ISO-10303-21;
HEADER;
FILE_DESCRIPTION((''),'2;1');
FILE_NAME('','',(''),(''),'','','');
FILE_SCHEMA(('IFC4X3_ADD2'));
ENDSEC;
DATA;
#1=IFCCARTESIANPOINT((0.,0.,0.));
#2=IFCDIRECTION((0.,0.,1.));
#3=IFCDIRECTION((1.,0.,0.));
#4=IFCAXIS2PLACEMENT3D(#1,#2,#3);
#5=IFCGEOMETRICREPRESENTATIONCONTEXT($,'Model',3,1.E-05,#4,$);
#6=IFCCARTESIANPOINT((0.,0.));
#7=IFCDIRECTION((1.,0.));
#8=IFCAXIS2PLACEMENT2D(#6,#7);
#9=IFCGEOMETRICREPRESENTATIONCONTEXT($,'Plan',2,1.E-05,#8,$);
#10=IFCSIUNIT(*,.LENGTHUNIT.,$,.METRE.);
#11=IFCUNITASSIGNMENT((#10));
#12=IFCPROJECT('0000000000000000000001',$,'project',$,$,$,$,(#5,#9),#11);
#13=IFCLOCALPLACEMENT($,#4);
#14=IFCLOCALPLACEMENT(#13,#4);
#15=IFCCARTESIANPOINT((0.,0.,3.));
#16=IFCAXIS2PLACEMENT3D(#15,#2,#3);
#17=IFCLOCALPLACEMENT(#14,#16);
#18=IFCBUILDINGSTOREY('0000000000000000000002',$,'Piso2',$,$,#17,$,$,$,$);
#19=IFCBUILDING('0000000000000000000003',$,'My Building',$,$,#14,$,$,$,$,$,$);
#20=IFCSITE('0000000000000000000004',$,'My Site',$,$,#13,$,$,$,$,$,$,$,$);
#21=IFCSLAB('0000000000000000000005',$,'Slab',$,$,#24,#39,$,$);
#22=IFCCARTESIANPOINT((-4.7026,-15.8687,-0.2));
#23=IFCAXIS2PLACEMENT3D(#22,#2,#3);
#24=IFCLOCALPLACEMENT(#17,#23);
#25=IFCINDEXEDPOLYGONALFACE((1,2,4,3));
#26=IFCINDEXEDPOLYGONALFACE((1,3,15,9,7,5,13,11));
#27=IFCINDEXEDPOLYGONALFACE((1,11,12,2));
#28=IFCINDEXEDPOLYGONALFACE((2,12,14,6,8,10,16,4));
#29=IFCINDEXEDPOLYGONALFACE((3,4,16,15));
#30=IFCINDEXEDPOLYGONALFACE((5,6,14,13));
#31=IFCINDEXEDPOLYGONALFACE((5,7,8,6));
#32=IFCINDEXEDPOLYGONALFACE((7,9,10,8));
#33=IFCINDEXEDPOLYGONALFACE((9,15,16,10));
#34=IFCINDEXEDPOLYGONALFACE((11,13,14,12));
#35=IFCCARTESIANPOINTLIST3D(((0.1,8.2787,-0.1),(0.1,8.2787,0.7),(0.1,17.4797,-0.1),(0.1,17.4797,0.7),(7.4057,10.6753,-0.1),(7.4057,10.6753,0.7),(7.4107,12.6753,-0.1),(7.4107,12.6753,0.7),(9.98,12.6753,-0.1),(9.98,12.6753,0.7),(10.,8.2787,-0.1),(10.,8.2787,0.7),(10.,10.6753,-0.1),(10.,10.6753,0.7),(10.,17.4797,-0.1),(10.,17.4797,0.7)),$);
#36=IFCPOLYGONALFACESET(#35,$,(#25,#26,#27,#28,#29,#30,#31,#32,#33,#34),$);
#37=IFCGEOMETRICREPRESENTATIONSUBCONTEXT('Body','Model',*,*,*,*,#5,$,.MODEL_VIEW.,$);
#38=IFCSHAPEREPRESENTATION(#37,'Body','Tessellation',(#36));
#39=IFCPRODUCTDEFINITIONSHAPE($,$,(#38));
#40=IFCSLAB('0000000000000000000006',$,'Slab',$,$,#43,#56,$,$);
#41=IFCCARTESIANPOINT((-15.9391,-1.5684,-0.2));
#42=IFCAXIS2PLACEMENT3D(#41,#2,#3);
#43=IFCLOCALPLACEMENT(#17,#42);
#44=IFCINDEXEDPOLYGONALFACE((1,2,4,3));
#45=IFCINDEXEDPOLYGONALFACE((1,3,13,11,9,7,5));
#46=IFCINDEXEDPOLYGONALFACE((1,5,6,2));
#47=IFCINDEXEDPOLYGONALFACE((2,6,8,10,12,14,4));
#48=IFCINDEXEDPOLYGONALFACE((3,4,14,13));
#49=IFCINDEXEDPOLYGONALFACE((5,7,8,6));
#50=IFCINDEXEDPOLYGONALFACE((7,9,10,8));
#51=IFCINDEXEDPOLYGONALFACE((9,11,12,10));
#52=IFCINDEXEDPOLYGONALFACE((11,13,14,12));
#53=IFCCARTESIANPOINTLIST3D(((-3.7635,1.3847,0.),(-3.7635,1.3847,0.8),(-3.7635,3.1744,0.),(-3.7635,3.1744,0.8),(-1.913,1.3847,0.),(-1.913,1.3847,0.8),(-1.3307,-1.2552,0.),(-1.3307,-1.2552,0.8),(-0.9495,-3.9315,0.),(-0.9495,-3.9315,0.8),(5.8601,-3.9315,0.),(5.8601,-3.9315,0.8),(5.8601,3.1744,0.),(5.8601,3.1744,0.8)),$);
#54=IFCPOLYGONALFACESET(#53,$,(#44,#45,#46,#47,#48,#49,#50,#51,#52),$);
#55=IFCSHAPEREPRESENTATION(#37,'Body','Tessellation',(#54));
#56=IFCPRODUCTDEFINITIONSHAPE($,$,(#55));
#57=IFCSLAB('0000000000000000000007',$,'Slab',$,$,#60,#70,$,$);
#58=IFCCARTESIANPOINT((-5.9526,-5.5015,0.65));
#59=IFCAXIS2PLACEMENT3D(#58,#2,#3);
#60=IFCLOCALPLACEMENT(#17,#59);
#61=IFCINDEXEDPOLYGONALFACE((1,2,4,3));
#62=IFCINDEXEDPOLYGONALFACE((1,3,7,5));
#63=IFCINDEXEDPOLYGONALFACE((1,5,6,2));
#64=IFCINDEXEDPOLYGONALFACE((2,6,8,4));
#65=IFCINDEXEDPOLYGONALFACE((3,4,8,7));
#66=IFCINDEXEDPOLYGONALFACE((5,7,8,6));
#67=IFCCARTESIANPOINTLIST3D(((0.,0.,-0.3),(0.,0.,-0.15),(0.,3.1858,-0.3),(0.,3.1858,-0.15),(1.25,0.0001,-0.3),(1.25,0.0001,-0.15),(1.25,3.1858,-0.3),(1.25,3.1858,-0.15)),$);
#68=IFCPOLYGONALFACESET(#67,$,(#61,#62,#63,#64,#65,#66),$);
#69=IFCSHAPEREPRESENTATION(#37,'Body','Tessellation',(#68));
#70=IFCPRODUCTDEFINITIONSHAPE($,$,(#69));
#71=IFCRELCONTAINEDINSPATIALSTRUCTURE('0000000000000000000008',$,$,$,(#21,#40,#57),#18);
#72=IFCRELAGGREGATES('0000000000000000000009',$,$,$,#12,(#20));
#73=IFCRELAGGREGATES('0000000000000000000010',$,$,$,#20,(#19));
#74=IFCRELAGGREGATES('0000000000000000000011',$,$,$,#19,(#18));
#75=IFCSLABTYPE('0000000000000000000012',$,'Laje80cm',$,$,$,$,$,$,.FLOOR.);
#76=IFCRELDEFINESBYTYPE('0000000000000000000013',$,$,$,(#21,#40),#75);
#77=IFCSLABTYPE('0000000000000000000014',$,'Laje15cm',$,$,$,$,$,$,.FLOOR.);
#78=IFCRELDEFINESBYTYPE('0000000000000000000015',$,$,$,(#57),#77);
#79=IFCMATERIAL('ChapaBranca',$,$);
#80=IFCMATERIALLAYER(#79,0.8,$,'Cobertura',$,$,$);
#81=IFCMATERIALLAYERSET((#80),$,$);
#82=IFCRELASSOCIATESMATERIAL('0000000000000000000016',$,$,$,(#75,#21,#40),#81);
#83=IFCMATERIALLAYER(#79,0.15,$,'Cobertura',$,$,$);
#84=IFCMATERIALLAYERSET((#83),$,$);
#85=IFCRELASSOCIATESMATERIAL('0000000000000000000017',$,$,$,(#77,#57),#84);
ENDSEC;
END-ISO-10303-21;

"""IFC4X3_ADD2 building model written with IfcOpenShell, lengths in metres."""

from ifc_helpers import new_model, si_unit, frame, origin_with_axes, origin_2d_with_axis, place, context, subcontext, project, spatial, line, indexed_curve, outline, extrude, material, layer, layer_set, layer_usage, type_object, element, save


model = new_model("IFC4X3_ADD2")

# Units and contexts
model_context = context("Model", 3, precision=1e-05, world=origin_with_axes())
plan_context = context("Plan", 2, precision=1e-05, world=origin_2d_with_axis())
body_context = subcontext(model_context, "Body", "Model", "MODEL_VIEW")
ifc_project = project(units=[si_unit("LENGTHUNIT", "METRE")], contexts=[model_context, plan_context])

# Site, building, storey
site_placement = place(None, origin_with_axes())
site = spatial("IfcSite", under=ifc_project, at=site_placement, Name="My Site")
building_placement = place(site_placement, origin_with_axes())
building = spatial("IfcBuilding", under=site, at=building_placement, Name="My Building")
storey_placement = place(building_placement, frame((0.0, 0.0, 3.0), z_axis=(0.0, 0.0, 1.0), x_axis=(1.0, 0.0, 0.0)))
storey = spatial("IfcBuildingStorey", under=building, at=storey_placement, Name="Piso2")

# Shared definitions
ifc_material_1 = material(Name="ChapaBranca")

# Slabs
ifc_layer_1 = layer(ifc_material_1, 0.8, Name="Cobertura")
ifc_layer_set_1 = layer_set([ifc_layer_1])
ifc_layer_usage_1 = layer_usage(ifc_layer_set_1, "AXIS3", "POSITIVE", -0.1)
slab_type_1 = type_object("IfcSlabType", Name="Laje80cm", PredefinedType="FLOOR", material=ifc_layer_set_1)
slab_1_placement = place(storey_placement, frame((-4.7026, -15.8687, -0.2), z_axis=(0.0, 0.0, 1.0), x_axis=(1.0, 0.0, 0.0)))
element("IfcSlab", 1, at=slab_1_placement, inside=storey, type_object=slab_type_1, material=ifc_layer_usage_1, Name="Slab", context=body_context, shape_type="SweptSolid", body=[
    extrude(outline(indexed_curve([(0.1, 8.2787), (0.1, 17.4797), (10.0, 17.4797), (9.98, 12.6753), (7.4107, 12.6753), (7.4057, 10.6753), (10.0, 10.6753), (10.0, 8.2787), (0.1, 8.2787)])), frame((0.0, 0.0, -0.1), z_axis=(0.0, 0.0, 1.0), x_axis=(1.0, 0.0, 0.0)), (0.0, 0.0, 1.0), 0.8),
])
ifc_layer_usage_2 = layer_usage(ifc_layer_set_1, "AXIS3", "POSITIVE", 0.0)
slab_2_placement = place(storey_placement, frame((-15.9391, -1.5684, -0.2), z_axis=(0.0, 0.0, 1.0), x_axis=(1.0, 0.0, 0.0)))
element("IfcSlab", 2, at=slab_2_placement, inside=storey, type_object=slab_type_1, material=ifc_layer_usage_2, Name="Slab", context=body_context, shape_type="SweptSolid", body=[
    extrude(outline(indexed_curve([(-3.1744, 5.8601), (3.9315, 5.8601), (3.9315, -0.9495), (1.2552, -1.3307), (-1.3847, -1.913), (-1.3847, -3.7635), (-3.1744, -3.7635)], segments=[line(1, 2, 3, 4, 5, 6, 7, 1)])), frame((0.0, 0.0, 0.0), z_axis=(0.0, 0.0, 1.0), x_axis=(0.0, -1.0, 0.0)), (0.0, 0.0, 1.0), 0.8),
])
ifc_layer_2 = layer(ifc_material_1, 0.15, Name="Cobertura")
ifc_layer_set_2 = layer_set([ifc_layer_2])
ifc_layer_usage_3 = layer_usage(ifc_layer_set_2, "AXIS3", "POSITIVE", -0.3)
slab_type_2 = type_object("IfcSlabType", Name="Laje15cm", PredefinedType="FLOOR", material=ifc_layer_set_2)
slab_3_placement = place(storey_placement, frame((-5.9526, -5.5015, 0.65), z_axis=(0.0, 0.0, 1.0), x_axis=(1.0, 0.0, 0.0)))
element("IfcSlab", 3, at=slab_3_placement, inside=storey, type_object=slab_type_2, material=ifc_layer_usage_3, Name="Slab", context=body_context, shape_type="SweptSolid", body=[
    extrude(outline(indexed_curve([(0.0, 0.0), (0.0, 3.1858), (1.25, 3.1858), (1.25, 0.0001), (0.0, 0.0)])), frame((0.0, 0.0, -0.3), z_axis=(0.0, 0.0, 1.0), x_axis=(1.0, 0.0, 0.0)), (0.0, 0.0, 1.0), 0.15),
])

save(model, "model.ifc")
